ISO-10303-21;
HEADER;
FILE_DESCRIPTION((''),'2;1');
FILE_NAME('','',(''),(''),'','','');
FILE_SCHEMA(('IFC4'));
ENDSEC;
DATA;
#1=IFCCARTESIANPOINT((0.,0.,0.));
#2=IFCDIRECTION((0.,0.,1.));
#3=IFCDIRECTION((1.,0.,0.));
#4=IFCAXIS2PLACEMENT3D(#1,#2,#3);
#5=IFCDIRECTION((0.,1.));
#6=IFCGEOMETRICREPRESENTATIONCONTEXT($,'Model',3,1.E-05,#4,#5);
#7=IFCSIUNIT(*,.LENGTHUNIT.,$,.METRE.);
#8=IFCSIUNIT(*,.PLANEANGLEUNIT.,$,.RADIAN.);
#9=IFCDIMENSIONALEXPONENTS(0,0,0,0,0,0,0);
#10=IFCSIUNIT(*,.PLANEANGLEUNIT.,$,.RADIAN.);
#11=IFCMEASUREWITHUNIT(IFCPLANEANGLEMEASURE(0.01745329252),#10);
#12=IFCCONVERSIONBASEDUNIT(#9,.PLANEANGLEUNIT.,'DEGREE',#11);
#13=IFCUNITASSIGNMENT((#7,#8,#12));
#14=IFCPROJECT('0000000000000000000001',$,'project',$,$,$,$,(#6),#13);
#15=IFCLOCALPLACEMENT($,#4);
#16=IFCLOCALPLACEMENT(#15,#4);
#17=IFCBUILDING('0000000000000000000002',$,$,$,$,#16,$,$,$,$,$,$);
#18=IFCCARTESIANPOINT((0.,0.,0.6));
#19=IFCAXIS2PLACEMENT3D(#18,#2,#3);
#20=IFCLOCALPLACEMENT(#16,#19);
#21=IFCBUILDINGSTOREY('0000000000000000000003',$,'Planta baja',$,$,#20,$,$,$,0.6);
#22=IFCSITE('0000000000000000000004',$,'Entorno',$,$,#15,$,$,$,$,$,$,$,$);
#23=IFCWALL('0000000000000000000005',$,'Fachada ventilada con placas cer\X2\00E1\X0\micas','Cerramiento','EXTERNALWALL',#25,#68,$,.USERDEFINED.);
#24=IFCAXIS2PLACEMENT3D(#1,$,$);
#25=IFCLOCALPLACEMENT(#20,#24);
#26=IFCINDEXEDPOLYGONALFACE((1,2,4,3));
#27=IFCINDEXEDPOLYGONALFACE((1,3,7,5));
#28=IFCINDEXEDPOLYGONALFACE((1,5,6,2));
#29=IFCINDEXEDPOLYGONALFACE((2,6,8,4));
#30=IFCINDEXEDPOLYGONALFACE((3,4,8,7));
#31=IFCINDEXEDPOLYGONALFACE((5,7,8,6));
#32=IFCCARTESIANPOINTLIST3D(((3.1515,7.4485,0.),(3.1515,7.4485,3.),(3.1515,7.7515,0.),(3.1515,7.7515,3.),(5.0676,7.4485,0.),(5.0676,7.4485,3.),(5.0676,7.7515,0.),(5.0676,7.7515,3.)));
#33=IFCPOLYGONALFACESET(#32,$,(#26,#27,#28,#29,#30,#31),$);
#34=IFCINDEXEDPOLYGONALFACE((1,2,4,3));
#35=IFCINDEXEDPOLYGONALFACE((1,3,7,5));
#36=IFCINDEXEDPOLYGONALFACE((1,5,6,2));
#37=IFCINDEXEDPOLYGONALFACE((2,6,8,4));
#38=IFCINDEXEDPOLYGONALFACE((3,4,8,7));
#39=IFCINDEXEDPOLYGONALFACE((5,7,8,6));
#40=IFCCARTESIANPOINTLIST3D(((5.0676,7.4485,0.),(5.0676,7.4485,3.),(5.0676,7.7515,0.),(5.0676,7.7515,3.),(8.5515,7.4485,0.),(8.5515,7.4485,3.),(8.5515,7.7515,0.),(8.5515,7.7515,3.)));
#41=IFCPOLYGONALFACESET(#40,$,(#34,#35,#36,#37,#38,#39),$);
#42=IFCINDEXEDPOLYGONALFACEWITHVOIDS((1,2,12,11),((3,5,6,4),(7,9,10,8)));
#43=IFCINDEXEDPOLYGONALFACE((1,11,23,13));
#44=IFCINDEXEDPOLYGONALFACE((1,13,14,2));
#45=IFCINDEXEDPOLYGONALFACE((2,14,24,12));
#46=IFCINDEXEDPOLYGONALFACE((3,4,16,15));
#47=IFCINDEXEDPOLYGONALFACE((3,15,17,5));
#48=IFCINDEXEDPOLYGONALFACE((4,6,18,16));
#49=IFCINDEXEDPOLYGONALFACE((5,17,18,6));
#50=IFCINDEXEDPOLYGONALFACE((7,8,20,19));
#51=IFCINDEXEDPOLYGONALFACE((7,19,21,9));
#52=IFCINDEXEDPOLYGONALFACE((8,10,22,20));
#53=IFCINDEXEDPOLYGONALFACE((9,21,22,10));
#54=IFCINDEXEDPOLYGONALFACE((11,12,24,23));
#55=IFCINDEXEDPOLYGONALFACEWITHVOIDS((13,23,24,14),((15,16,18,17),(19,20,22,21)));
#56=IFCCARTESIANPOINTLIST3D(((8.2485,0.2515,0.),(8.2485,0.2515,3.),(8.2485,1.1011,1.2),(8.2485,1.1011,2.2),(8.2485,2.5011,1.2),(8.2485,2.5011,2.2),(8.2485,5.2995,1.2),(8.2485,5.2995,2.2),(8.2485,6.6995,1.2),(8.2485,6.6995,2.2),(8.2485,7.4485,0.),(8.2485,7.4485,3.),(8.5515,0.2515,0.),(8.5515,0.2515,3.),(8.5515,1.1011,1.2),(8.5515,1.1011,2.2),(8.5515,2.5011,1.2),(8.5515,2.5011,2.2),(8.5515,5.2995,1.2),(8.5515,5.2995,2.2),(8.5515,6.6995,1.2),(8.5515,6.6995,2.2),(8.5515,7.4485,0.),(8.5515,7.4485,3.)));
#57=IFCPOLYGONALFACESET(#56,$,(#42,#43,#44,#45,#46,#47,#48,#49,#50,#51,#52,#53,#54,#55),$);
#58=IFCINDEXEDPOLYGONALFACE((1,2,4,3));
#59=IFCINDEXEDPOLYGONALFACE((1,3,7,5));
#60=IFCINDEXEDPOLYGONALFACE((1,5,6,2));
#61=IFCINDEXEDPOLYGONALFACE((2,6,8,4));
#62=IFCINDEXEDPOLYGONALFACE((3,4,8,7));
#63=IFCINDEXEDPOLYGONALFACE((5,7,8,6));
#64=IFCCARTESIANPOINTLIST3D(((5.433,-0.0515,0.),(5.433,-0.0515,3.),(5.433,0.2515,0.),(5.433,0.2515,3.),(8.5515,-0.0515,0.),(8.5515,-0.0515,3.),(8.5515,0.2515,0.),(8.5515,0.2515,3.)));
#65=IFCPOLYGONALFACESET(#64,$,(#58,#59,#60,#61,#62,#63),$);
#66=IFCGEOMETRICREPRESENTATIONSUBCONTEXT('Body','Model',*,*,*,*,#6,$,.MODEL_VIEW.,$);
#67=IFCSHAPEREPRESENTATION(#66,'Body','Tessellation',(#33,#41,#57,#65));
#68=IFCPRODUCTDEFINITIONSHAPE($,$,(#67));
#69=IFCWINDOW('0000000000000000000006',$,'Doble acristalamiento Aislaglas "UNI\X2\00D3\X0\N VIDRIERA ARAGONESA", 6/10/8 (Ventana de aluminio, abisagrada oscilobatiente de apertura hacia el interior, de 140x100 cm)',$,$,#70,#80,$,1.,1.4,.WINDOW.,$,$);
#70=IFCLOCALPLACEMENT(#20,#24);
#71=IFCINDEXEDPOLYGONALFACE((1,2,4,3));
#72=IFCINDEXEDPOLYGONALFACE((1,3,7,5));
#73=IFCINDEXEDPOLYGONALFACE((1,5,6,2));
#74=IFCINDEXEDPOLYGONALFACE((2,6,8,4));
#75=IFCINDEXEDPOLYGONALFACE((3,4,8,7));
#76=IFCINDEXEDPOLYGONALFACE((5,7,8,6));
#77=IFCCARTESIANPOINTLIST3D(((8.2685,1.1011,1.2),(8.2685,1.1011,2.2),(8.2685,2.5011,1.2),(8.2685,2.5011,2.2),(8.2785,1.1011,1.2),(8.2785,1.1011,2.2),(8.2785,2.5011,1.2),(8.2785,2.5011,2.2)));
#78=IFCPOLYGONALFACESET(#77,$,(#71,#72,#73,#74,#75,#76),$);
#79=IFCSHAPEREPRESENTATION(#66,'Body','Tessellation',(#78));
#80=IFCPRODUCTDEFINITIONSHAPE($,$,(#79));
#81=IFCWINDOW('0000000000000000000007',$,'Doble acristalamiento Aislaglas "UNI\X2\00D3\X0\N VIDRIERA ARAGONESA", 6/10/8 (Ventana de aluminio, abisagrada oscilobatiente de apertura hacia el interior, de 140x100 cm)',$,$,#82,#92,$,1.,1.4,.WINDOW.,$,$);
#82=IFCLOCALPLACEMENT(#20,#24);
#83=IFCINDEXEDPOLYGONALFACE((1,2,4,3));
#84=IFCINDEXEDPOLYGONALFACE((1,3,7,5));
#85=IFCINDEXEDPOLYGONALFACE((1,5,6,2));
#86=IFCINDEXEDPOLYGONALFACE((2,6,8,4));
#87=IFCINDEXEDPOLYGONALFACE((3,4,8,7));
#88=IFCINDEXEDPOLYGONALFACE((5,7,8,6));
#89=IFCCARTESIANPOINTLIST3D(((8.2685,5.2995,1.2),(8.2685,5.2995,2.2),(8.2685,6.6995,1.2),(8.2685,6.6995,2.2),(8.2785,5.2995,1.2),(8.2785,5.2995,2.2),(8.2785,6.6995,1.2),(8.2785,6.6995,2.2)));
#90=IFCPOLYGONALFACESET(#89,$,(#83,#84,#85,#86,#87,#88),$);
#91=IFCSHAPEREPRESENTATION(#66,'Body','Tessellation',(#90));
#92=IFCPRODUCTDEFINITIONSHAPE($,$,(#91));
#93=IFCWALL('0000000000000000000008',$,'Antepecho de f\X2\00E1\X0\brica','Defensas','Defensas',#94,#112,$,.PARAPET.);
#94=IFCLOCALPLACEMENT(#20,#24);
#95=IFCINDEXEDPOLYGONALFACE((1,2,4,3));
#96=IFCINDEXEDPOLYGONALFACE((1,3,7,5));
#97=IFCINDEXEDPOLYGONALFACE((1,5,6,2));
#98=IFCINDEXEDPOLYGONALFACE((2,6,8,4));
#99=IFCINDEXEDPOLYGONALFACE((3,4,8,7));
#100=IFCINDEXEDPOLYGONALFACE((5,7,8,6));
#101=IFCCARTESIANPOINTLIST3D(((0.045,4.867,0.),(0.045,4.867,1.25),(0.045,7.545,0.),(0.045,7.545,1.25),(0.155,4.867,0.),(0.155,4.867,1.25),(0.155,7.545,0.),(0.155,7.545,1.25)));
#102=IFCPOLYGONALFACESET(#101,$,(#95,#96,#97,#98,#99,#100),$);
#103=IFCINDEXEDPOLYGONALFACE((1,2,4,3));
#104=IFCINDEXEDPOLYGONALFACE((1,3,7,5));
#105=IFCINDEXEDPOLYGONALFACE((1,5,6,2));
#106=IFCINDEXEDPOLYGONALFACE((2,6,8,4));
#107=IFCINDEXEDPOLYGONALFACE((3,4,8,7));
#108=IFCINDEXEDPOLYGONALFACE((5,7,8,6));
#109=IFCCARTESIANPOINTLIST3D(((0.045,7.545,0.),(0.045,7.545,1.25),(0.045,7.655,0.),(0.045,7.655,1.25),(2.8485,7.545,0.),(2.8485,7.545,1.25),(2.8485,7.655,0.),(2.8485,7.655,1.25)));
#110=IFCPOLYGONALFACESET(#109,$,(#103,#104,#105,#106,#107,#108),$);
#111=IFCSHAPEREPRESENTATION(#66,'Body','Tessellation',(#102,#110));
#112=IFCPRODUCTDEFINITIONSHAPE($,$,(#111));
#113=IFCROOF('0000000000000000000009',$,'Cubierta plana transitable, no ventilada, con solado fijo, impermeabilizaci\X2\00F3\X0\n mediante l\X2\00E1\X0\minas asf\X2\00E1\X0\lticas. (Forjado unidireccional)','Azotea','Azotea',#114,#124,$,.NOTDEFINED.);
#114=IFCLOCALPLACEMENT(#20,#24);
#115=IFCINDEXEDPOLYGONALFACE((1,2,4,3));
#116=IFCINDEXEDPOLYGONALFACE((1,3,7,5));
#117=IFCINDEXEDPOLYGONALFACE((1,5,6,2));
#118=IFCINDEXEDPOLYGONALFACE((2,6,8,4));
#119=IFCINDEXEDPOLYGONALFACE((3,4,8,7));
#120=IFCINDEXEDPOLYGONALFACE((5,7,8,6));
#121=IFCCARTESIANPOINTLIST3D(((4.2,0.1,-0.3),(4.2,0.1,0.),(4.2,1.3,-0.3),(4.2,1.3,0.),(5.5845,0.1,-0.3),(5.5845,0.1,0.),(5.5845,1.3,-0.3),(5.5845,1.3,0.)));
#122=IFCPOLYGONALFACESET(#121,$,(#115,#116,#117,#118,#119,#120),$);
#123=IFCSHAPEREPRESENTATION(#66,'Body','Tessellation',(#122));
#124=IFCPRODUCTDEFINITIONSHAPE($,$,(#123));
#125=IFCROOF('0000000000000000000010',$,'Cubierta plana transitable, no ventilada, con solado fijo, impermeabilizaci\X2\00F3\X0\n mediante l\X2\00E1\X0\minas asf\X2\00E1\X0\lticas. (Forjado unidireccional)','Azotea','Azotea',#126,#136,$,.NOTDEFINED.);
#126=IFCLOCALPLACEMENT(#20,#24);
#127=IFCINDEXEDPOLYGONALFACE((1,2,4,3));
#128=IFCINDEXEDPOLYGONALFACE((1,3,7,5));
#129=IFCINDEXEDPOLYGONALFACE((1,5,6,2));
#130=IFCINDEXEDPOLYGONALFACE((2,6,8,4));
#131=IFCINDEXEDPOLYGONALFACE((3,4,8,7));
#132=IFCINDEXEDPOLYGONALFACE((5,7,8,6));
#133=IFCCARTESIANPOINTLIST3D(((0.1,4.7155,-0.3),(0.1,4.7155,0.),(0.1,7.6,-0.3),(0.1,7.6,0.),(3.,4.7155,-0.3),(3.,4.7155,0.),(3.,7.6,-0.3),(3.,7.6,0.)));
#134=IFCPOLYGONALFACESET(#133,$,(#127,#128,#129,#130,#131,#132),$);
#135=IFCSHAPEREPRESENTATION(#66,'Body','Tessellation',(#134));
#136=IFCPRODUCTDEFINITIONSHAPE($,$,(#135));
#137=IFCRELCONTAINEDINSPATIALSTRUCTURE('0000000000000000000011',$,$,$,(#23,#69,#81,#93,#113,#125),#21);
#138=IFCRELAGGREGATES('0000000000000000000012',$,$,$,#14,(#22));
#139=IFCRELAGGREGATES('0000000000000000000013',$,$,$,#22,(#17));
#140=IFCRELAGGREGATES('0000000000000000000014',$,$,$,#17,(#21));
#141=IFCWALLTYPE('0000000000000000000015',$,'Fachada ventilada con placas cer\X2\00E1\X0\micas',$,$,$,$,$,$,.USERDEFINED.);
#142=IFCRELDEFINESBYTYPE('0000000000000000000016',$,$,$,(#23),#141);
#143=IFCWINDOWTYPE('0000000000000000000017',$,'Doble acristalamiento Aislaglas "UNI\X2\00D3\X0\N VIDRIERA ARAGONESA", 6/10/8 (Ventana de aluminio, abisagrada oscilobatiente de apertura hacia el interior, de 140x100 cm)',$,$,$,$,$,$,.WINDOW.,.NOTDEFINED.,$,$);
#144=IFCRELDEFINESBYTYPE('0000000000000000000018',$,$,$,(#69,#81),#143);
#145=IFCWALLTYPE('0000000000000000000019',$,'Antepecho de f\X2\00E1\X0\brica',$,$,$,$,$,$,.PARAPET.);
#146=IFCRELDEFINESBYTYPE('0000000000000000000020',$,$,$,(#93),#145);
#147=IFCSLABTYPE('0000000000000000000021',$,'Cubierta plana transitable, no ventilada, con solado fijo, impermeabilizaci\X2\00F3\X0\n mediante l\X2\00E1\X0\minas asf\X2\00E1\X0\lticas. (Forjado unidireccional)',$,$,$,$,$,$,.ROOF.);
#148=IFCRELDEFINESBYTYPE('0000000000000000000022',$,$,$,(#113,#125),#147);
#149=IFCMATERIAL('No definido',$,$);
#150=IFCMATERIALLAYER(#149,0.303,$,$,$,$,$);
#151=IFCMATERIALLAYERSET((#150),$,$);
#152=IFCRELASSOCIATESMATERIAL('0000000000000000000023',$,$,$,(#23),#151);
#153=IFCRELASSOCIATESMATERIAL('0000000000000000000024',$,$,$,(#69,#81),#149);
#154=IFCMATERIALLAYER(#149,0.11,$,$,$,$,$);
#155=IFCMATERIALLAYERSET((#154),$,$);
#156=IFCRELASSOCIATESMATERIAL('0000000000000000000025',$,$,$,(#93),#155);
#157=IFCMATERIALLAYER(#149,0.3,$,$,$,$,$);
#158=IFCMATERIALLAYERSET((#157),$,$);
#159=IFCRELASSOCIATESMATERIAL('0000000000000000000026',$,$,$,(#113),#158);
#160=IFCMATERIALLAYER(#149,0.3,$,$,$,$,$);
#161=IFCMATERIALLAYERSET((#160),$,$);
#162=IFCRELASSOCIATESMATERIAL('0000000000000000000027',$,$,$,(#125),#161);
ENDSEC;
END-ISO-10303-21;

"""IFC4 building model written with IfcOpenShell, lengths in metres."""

from ifc_helpers import new_model, entity, si_unit, converted_unit, direction, frame, origin_with_axes, origin_2d_with_axis, place, context, subcontext, project, spatial, polyline, rectangle, outline, extrude, shape, material, layer, layer_set, layer_usage, type_object, element, fill, save


model = new_model("IFC4")

# Units and contexts
model_context = context("Model", 3, precision=1e-05, world=origin_with_axes(), true_north=direction((0.0, 1.0)))
body_context = subcontext(model_context, "Body", "Model", "MODEL_VIEW")
footprint_context = subcontext(model_context, "FootPrint", "Model", "MODEL_VIEW")
ifc_project = project(units=[si_unit("LENGTHUNIT", "METRE"), si_unit("PLANEANGLEUNIT", "RADIAN"), converted_unit("PLANEANGLEUNIT", "DEGREE", entity("IfcPlaneAngleMeasure", 0.01745329252), si_unit("PLANEANGLEUNIT", "RADIAN"), dimensions=[0, 0, 0, 0, 0, 0, 0])], contexts=[model_context])

# Site, building, storey
site_placement = place(None, origin_with_axes())
site = spatial("IfcSite", under=ifc_project, at=site_placement, Name="Entorno")
building_placement = place(site_placement, origin_with_axes())
building = spatial("IfcBuilding", under=site, at=building_placement)
storey_placement = place(building_placement, frame((0.0, 0.0, 0.6), z_axis=(0.0, 0.0, 1.0), x_axis=(1.0, 0.0, 0.0)))
storey = spatial("IfcBuildingStorey", under=building, at=storey_placement, Name="Planta baja", Elevation=0.6)

# Shared definitions
ifc_material = material(Name="No definido")

# Shared definitions
wall_type_1 = type_object("IfcWallType", Name="Fachada ventilada con placas cerámicas", PredefinedType="USERDEFINED")

# Wall, openings, windows
ifc_layer_1 = layer(ifc_material, 0.303)
ifc_layer_set_1 = layer_set([ifc_layer_1])
ifc_layer_usage_1 = layer_usage(ifc_layer_set_1, "AXIS2", "POSITIVE", -0.1515)
wall_1_placement = place(storey_placement, frame((3.0, 7.6, 0.0), z_axis=(0.0, 0.0, 1.0), x_axis=(1.0, 0.0, 0.0)))
cartesian_point_1 = entity("IfcCartesianPoint", [-0.958, -1.5])
cartesian_point_2 = entity("IfcCartesianPoint", [-0.958, -1.5])
cartesian_point_3 = entity("IfcCartesianPoint", [-1.742, -1.5])
cartesian_point_4 = entity("IfcCartesianPoint", [-1.742, -1.5])
cartesian_point_5 = entity("IfcCartesianPoint", [-3.5985, -1.5])
cartesian_point_6 = entity("IfcCartesianPoint", [-3.5985, -1.5])
cartesian_point_7 = entity("IfcCartesianPoint", [-1.5593, -1.5])
cartesian_point_8 = entity("IfcCartesianPoint", [-1.5593, -1.5])
wall_1 = element("IfcWall", 1, at=wall_1_placement, inside=storey, type_object=wall_type_1, material=ifc_layer_usage_1, Name="Fachada ventilada con placas cerámicas", Description="Cerramiento", ObjectType="EXTERNALWALL", PredefinedType="USERDEFINED", context=body_context, shape_type="SolidModel", body=[
    entity("IfcExtrudedAreaSolidTapered", entity("IfcArbitraryClosedProfileDef", "AREA", None, entity("IfcPolyline", [cartesian_point_1, entity("IfcCartesianPoint", [0.958, -1.5]), entity("IfcCartesianPoint", [0.958, 1.5]), entity("IfcCartesianPoint", [-0.958, 1.5]), cartesian_point_1])), entity("IfcAxis2Placement3D", entity("IfcCartesianPoint", [1.1096, 0.1515, 1.5]), entity("IfcDirection", [0.0, -1.0, 0.0]), entity("IfcDirection", [1.0, 0.0, 0.0])), entity("IfcDirection", [0.0, 0.0, 1.0]), 0.303, entity("IfcArbitraryClosedProfileDef", "AREA", None, entity("IfcPolyline", [cartesian_point_2, entity("IfcCartesianPoint", [0.958, -1.5]), entity("IfcCartesianPoint", [0.958, 1.5]), entity("IfcCartesianPoint", [-0.958, 1.5]), cartesian_point_2]))),
    entity("IfcExtrudedAreaSolidTapered", entity("IfcArbitraryClosedProfileDef", "AREA", None, entity("IfcPolyline", [cartesian_point_3, entity("IfcCartesianPoint", [1.742, -1.5]), entity("IfcCartesianPoint", [1.742, 1.5]), entity("IfcCartesianPoint", [-1.742, 1.5]), cartesian_point_3])), entity("IfcAxis2Placement3D", entity("IfcCartesianPoint", [3.8096, 0.1515, 1.5]), entity("IfcDirection", [0.0, -1.0, 0.0]), entity("IfcDirection", [1.0, 0.0, 0.0])), entity("IfcDirection", [0.0, 0.0, 1.0]), 0.303, entity("IfcArbitraryClosedProfileDef", "AREA", None, entity("IfcPolyline", [cartesian_point_4, entity("IfcCartesianPoint", [1.742, -1.5]), entity("IfcCartesianPoint", [1.742, 1.5]), entity("IfcCartesianPoint", [-1.742, 1.5]), cartesian_point_4]))),
    entity("IfcExtrudedAreaSolidTapered", entity("IfcArbitraryClosedProfileDef", "AREA", None, entity("IfcPolyline", [cartesian_point_5, entity("IfcCartesianPoint", [3.5985, -1.5]), entity("IfcCartesianPoint", [3.5985, 1.5]), entity("IfcCartesianPoint", [-3.5985, 1.5]), cartesian_point_5])), entity("IfcAxis2Placement3D", entity("IfcCartesianPoint", [5.5515, -3.75, 1.5]), entity("IfcDirection", [-1.0, 0.0, 0.0]), entity("IfcDirection", [0.0, -1.0, 0.0])), entity("IfcDirection", [0.0, 0.0, 1.0]), 0.303, entity("IfcArbitraryClosedProfileDef", "AREA", None, entity("IfcPolyline", [cartesian_point_6, entity("IfcCartesianPoint", [3.5985, -1.5]), entity("IfcCartesianPoint", [3.5985, 1.5]), entity("IfcCartesianPoint", [-3.5985, 1.5]), cartesian_point_6]))),
    entity("IfcExtrudedAreaSolidTapered", entity("IfcArbitraryClosedProfileDef", "AREA", None, entity("IfcPolyline", [cartesian_point_7, entity("IfcCartesianPoint", [1.5593, -1.5]), entity("IfcCartesianPoint", [1.5593, 1.5]), entity("IfcCartesianPoint", [-1.5593, 1.5]), cartesian_point_7])), entity("IfcAxis2Placement3D", entity("IfcCartesianPoint", [3.9922, -7.6515, 1.5]), entity("IfcDirection", [0.0, 1.0, 0.0]), entity("IfcDirection", [-1.0, 0.0, 0.0])), entity("IfcDirection", [0.0, 0.0, 1.0]), 0.303, entity("IfcArbitraryClosedProfileDef", "AREA", None, entity("IfcPolyline", [cartesian_point_8, entity("IfcCartesianPoint", [1.5593, -1.5]), entity("IfcCartesianPoint", [1.5593, 1.5]), entity("IfcCartesianPoint", [-1.5593, 1.5]), cartesian_point_8]))),
])
opening_1_placement = place(wall_1_placement, frame((5.4, -5.7989, 1.7), z_axis=(0.0, 0.0, 1.0), x_axis=(0.0, -1.0, 0.0)))
cartesian_point_9 = entity("IfcCartesianPoint", [-0.7, -0.1515])
opening_1 = element("IfcOpeningElement", 2, at=opening_1_placement, cuts=wall_1, ObjectType="No definido", PredefinedType="OPENING", shapes=[
    shape(body_context, "Body", "SweptSolid", [extrude(rectangle(XDim=1.0, YDim=1.4, at=origin_2d_with_axis()), frame((0.0, -0.1515, 0.0), z_axis=(0.0, 1.0, 0.0), x_axis=(0.0, 0.0, 1.0)), (0.0, 0.0, 1.0), 0.303)]),
    shape(footprint_context, "FootPrint", "GeometricCurveSet", [entity("IfcGeometricCurveSet", [entity("IfcPolyline", [cartesian_point_9, entity("IfcCartesianPoint", [0.7, -0.1515]), entity("IfcCartesianPoint", [0.7, 0.1515]), entity("IfcCartesianPoint", [-0.7, 0.1515]), cartesian_point_9])])]),
])
opening_2_placement = place(wall_1_placement, frame((5.4, -1.6005, 1.7), z_axis=(0.0, 0.0, 1.0), x_axis=(0.0, -1.0, 0.0)))
cartesian_point_10 = entity("IfcCartesianPoint", [-0.7, -0.1515])
opening_2 = element("IfcOpeningElement", 3, at=opening_2_placement, cuts=wall_1, ObjectType="No definido", PredefinedType="OPENING", shapes=[
    shape(body_context, "Body", "SweptSolid", [extrude(rectangle(XDim=1.0, YDim=1.4, at=origin_2d_with_axis()), frame((0.0, -0.1515, 0.0), z_axis=(0.0, 1.0, 0.0), x_axis=(0.0, 0.0, 1.0)), (0.0, 0.0, 1.0), 0.303)]),
    shape(footprint_context, "FootPrint", "GeometricCurveSet", [entity("IfcGeometricCurveSet", [entity("IfcPolyline", [cartesian_point_10, entity("IfcCartesianPoint", [0.7, -0.1515]), entity("IfcCartesianPoint", [0.7, 0.1515]), entity("IfcCartesianPoint", [-0.7, 0.1515]), cartesian_point_10])])]),
])
window_type_1 = type_object("IfcWindowType", Name="Doble acristalamiento Aislaglas \"UNIÓN VIDRIERA ARAGONESA\", 6/10/8 (Ventana de aluminio, abisagrada oscilobatiente de apertura hacia el interior, de 140x100 cm)", PartitioningType="NOTDEFINED", PredefinedType="WINDOW")
window_1_placement = place(opening_1_placement, frame((0.0, -0.1265, 0.0), z_axis=(0.0, 0.0, 1.0), x_axis=(1.0, 0.0, 0.0)))
window_1 = element("IfcWindow", 4, at=window_1_placement, inside=storey, type_object=window_type_1, material=ifc_material, Name="Doble acristalamiento Aislaglas \"UNIÓN VIDRIERA ARAGONESA\", 6/10/8 (Ventana de aluminio, abisagrada oscilobatiente de apertura hacia el interior, de 140x100 cm)", OverallHeight=1.0, OverallWidth=1.4, PredefinedType="WINDOW", context=body_context, shape_type="SweptSolid", body=[
    extrude(rectangle(XDim=1.4, YDim=1.0, at=origin_2d_with_axis()), frame((0.0, 0.005, 0.0), z_axis=(0.0, -1.0, 0.0), x_axis=(1.0, 0.0, 0.0)), (0.0, 0.0, 1.0), 0.01),
])
fill(opening_1, window_1)
window_2_placement = place(opening_2_placement, frame((0.0, -0.1265, 0.0), z_axis=(0.0, 0.0, 1.0), x_axis=(1.0, 0.0, 0.0)))
window_2 = element("IfcWindow", 5, at=window_2_placement, inside=storey, type_object=window_type_1, material=ifc_material, Name="Doble acristalamiento Aislaglas \"UNIÓN VIDRIERA ARAGONESA\", 6/10/8 (Ventana de aluminio, abisagrada oscilobatiente de apertura hacia el interior, de 140x100 cm)", OverallHeight=1.0, OverallWidth=1.4, PredefinedType="WINDOW", context=body_context, shape_type="SweptSolid", body=[
    extrude(rectangle(XDim=1.4, YDim=1.0, at=origin_2d_with_axis()), frame((0.0, 0.005, 0.0), z_axis=(0.0, -1.0, 0.0), x_axis=(1.0, 0.0, 0.0)), (0.0, 0.0, 1.0), 0.01),
])
fill(opening_2, window_2)

# Wall
ifc_layer_2 = layer(ifc_material, 0.11)
ifc_layer_set_2 = layer_set([ifc_layer_2])
ifc_layer_usage_2 = layer_usage(ifc_layer_set_2, "AXIS2", "POSITIVE", -0.055)
wall_type_2 = type_object("IfcWallType", Name="Antepecho de fábrica", PredefinedType="PARAPET")
wall_2_placement = place(storey_placement, frame((0.1, 4.848, 0.0), z_axis=(0.0, 0.0, 1.0), x_axis=(0.0, 1.0, 0.0)))
cartesian_point_11 = entity("IfcCartesianPoint", [-1.339, -0.625])
cartesian_point_12 = entity("IfcCartesianPoint", [-1.339, -0.625])
cartesian_point_13 = entity("IfcCartesianPoint", [-1.4018, -0.625])
cartesian_point_14 = entity("IfcCartesianPoint", [-1.4018, -0.625])
element("IfcWall", 6, at=wall_2_placement, inside=storey, type_object=wall_type_2, material=ifc_layer_usage_2, Name="Antepecho de fábrica", Description="Defensas", ObjectType="Defensas", PredefinedType="PARAPET", context=body_context, shape_type="SolidModel", body=[
    entity("IfcExtrudedAreaSolidTapered", entity("IfcArbitraryClosedProfileDef", "AREA", None, entity("IfcPolyline", [cartesian_point_11, entity("IfcCartesianPoint", [1.339, -0.625]), entity("IfcCartesianPoint", [1.339, 0.625]), entity("IfcCartesianPoint", [-1.339, 0.625]), cartesian_point_11])), entity("IfcAxis2Placement3D", entity("IfcCartesianPoint", [1.358, 0.055, 0.625]), entity("IfcDirection", [0.0, -1.0, 0.0]), entity("IfcDirection", [1.0, 0.0, 0.0])), entity("IfcDirection", [0.0, 0.0, 1.0]), 0.11, entity("IfcArbitraryClosedProfileDef", "AREA", None, entity("IfcPolyline", [cartesian_point_12, entity("IfcCartesianPoint", [1.339, -0.625]), entity("IfcCartesianPoint", [1.339, 0.625]), entity("IfcCartesianPoint", [-1.339, 0.625]), cartesian_point_12]))),
    entity("IfcExtrudedAreaSolidTapered", entity("IfcArbitraryClosedProfileDef", "AREA", None, entity("IfcPolyline", [cartesian_point_13, entity("IfcCartesianPoint", [1.4018, -0.625]), entity("IfcCartesianPoint", [1.4018, 0.625]), entity("IfcCartesianPoint", [-1.4018, 0.625]), cartesian_point_13])), entity("IfcAxis2Placement3D", entity("IfcCartesianPoint", [2.807, -1.3467, 0.625]), entity("IfcDirection", [-1.0, 0.0, 0.0]), entity("IfcDirection", [0.0, -1.0, 0.0])), entity("IfcDirection", [0.0, 0.0, 1.0]), 0.11, entity("IfcArbitraryClosedProfileDef", "AREA", None, entity("IfcPolyline", [cartesian_point_14, entity("IfcCartesianPoint", [1.4018, -0.625]), entity("IfcCartesianPoint", [1.4018, 0.625]), entity("IfcCartesianPoint", [-1.4018, 0.625]), cartesian_point_14]))),
])

# Roofs
ifc_layer_3 = layer(ifc_material, 0.3)
ifc_layer_set_3 = layer_set([ifc_layer_3])
ifc_layer_usage_3 = layer_usage(ifc_layer_set_3, "AXIS3", "POSITIVE", 0.0)
slab_type_1 = type_object("IfcSlabType", Name="Cubierta plana transitable, no ventilada, con solado fijo, impermeabilización mediante láminas asfálticas. (Forjado unidireccional)", PredefinedType="ROOF")
roof_1_placement = place(storey_placement, frame((5.5845, 0.1, -0.3), z_axis=(0.0, 0.0, 1.0), x_axis=(1.0, 0.0, 0.0)))
element("IfcRoof", 7, at=roof_1_placement, inside=storey, type_object=slab_type_1, material=ifc_layer_usage_3, Name="Cubierta plana transitable, no ventilada, con solado fijo, impermeabilización mediante láminas asfálticas. (Forjado unidireccional)", Description="Azotea", ObjectType="Azotea", PredefinedType="NOTDEFINED", context=body_context, shape_type="SweptSolid", body=[
    extrude(outline(polyline([(0.0, 0.0), (0.0, 1.2), (-1.3845, 1.2), (-1.3845, 0.0), (0.0, 0.0)])), origin_with_axes(), (0.0, 0.0, 1.0), 0.3),
])
ifc_layer_4 = layer(ifc_material, 0.3)
ifc_layer_set_4 = layer_set([ifc_layer_4])
ifc_layer_usage_4 = layer_usage(ifc_layer_set_4, "AXIS3", "POSITIVE", 0.0)
roof_2_placement = place(storey_placement, frame((0.1, 7.6, -0.3), z_axis=(0.0, 0.0, 1.0), x_axis=(1.0, 0.0, 0.0)))
element("IfcRoof", 8, at=roof_2_placement, inside=storey, type_object=slab_type_1, material=ifc_layer_usage_4, Name="Cubierta plana transitable, no ventilada, con solado fijo, impermeabilización mediante láminas asfálticas. (Forjado unidireccional)", Description="Azotea", ObjectType="Azotea", PredefinedType="NOTDEFINED", context=body_context, shape_type="SweptSolid", body=[
    extrude(outline(polyline([(0.0, 0.0), (0.0, -2.8845), (2.9, -2.8845), (2.9, 0.0), (0.0, 0.0)])), origin_with_axes(), (0.0, 0.0, 1.0), 0.3),
])

save(model, "model.ifc")
